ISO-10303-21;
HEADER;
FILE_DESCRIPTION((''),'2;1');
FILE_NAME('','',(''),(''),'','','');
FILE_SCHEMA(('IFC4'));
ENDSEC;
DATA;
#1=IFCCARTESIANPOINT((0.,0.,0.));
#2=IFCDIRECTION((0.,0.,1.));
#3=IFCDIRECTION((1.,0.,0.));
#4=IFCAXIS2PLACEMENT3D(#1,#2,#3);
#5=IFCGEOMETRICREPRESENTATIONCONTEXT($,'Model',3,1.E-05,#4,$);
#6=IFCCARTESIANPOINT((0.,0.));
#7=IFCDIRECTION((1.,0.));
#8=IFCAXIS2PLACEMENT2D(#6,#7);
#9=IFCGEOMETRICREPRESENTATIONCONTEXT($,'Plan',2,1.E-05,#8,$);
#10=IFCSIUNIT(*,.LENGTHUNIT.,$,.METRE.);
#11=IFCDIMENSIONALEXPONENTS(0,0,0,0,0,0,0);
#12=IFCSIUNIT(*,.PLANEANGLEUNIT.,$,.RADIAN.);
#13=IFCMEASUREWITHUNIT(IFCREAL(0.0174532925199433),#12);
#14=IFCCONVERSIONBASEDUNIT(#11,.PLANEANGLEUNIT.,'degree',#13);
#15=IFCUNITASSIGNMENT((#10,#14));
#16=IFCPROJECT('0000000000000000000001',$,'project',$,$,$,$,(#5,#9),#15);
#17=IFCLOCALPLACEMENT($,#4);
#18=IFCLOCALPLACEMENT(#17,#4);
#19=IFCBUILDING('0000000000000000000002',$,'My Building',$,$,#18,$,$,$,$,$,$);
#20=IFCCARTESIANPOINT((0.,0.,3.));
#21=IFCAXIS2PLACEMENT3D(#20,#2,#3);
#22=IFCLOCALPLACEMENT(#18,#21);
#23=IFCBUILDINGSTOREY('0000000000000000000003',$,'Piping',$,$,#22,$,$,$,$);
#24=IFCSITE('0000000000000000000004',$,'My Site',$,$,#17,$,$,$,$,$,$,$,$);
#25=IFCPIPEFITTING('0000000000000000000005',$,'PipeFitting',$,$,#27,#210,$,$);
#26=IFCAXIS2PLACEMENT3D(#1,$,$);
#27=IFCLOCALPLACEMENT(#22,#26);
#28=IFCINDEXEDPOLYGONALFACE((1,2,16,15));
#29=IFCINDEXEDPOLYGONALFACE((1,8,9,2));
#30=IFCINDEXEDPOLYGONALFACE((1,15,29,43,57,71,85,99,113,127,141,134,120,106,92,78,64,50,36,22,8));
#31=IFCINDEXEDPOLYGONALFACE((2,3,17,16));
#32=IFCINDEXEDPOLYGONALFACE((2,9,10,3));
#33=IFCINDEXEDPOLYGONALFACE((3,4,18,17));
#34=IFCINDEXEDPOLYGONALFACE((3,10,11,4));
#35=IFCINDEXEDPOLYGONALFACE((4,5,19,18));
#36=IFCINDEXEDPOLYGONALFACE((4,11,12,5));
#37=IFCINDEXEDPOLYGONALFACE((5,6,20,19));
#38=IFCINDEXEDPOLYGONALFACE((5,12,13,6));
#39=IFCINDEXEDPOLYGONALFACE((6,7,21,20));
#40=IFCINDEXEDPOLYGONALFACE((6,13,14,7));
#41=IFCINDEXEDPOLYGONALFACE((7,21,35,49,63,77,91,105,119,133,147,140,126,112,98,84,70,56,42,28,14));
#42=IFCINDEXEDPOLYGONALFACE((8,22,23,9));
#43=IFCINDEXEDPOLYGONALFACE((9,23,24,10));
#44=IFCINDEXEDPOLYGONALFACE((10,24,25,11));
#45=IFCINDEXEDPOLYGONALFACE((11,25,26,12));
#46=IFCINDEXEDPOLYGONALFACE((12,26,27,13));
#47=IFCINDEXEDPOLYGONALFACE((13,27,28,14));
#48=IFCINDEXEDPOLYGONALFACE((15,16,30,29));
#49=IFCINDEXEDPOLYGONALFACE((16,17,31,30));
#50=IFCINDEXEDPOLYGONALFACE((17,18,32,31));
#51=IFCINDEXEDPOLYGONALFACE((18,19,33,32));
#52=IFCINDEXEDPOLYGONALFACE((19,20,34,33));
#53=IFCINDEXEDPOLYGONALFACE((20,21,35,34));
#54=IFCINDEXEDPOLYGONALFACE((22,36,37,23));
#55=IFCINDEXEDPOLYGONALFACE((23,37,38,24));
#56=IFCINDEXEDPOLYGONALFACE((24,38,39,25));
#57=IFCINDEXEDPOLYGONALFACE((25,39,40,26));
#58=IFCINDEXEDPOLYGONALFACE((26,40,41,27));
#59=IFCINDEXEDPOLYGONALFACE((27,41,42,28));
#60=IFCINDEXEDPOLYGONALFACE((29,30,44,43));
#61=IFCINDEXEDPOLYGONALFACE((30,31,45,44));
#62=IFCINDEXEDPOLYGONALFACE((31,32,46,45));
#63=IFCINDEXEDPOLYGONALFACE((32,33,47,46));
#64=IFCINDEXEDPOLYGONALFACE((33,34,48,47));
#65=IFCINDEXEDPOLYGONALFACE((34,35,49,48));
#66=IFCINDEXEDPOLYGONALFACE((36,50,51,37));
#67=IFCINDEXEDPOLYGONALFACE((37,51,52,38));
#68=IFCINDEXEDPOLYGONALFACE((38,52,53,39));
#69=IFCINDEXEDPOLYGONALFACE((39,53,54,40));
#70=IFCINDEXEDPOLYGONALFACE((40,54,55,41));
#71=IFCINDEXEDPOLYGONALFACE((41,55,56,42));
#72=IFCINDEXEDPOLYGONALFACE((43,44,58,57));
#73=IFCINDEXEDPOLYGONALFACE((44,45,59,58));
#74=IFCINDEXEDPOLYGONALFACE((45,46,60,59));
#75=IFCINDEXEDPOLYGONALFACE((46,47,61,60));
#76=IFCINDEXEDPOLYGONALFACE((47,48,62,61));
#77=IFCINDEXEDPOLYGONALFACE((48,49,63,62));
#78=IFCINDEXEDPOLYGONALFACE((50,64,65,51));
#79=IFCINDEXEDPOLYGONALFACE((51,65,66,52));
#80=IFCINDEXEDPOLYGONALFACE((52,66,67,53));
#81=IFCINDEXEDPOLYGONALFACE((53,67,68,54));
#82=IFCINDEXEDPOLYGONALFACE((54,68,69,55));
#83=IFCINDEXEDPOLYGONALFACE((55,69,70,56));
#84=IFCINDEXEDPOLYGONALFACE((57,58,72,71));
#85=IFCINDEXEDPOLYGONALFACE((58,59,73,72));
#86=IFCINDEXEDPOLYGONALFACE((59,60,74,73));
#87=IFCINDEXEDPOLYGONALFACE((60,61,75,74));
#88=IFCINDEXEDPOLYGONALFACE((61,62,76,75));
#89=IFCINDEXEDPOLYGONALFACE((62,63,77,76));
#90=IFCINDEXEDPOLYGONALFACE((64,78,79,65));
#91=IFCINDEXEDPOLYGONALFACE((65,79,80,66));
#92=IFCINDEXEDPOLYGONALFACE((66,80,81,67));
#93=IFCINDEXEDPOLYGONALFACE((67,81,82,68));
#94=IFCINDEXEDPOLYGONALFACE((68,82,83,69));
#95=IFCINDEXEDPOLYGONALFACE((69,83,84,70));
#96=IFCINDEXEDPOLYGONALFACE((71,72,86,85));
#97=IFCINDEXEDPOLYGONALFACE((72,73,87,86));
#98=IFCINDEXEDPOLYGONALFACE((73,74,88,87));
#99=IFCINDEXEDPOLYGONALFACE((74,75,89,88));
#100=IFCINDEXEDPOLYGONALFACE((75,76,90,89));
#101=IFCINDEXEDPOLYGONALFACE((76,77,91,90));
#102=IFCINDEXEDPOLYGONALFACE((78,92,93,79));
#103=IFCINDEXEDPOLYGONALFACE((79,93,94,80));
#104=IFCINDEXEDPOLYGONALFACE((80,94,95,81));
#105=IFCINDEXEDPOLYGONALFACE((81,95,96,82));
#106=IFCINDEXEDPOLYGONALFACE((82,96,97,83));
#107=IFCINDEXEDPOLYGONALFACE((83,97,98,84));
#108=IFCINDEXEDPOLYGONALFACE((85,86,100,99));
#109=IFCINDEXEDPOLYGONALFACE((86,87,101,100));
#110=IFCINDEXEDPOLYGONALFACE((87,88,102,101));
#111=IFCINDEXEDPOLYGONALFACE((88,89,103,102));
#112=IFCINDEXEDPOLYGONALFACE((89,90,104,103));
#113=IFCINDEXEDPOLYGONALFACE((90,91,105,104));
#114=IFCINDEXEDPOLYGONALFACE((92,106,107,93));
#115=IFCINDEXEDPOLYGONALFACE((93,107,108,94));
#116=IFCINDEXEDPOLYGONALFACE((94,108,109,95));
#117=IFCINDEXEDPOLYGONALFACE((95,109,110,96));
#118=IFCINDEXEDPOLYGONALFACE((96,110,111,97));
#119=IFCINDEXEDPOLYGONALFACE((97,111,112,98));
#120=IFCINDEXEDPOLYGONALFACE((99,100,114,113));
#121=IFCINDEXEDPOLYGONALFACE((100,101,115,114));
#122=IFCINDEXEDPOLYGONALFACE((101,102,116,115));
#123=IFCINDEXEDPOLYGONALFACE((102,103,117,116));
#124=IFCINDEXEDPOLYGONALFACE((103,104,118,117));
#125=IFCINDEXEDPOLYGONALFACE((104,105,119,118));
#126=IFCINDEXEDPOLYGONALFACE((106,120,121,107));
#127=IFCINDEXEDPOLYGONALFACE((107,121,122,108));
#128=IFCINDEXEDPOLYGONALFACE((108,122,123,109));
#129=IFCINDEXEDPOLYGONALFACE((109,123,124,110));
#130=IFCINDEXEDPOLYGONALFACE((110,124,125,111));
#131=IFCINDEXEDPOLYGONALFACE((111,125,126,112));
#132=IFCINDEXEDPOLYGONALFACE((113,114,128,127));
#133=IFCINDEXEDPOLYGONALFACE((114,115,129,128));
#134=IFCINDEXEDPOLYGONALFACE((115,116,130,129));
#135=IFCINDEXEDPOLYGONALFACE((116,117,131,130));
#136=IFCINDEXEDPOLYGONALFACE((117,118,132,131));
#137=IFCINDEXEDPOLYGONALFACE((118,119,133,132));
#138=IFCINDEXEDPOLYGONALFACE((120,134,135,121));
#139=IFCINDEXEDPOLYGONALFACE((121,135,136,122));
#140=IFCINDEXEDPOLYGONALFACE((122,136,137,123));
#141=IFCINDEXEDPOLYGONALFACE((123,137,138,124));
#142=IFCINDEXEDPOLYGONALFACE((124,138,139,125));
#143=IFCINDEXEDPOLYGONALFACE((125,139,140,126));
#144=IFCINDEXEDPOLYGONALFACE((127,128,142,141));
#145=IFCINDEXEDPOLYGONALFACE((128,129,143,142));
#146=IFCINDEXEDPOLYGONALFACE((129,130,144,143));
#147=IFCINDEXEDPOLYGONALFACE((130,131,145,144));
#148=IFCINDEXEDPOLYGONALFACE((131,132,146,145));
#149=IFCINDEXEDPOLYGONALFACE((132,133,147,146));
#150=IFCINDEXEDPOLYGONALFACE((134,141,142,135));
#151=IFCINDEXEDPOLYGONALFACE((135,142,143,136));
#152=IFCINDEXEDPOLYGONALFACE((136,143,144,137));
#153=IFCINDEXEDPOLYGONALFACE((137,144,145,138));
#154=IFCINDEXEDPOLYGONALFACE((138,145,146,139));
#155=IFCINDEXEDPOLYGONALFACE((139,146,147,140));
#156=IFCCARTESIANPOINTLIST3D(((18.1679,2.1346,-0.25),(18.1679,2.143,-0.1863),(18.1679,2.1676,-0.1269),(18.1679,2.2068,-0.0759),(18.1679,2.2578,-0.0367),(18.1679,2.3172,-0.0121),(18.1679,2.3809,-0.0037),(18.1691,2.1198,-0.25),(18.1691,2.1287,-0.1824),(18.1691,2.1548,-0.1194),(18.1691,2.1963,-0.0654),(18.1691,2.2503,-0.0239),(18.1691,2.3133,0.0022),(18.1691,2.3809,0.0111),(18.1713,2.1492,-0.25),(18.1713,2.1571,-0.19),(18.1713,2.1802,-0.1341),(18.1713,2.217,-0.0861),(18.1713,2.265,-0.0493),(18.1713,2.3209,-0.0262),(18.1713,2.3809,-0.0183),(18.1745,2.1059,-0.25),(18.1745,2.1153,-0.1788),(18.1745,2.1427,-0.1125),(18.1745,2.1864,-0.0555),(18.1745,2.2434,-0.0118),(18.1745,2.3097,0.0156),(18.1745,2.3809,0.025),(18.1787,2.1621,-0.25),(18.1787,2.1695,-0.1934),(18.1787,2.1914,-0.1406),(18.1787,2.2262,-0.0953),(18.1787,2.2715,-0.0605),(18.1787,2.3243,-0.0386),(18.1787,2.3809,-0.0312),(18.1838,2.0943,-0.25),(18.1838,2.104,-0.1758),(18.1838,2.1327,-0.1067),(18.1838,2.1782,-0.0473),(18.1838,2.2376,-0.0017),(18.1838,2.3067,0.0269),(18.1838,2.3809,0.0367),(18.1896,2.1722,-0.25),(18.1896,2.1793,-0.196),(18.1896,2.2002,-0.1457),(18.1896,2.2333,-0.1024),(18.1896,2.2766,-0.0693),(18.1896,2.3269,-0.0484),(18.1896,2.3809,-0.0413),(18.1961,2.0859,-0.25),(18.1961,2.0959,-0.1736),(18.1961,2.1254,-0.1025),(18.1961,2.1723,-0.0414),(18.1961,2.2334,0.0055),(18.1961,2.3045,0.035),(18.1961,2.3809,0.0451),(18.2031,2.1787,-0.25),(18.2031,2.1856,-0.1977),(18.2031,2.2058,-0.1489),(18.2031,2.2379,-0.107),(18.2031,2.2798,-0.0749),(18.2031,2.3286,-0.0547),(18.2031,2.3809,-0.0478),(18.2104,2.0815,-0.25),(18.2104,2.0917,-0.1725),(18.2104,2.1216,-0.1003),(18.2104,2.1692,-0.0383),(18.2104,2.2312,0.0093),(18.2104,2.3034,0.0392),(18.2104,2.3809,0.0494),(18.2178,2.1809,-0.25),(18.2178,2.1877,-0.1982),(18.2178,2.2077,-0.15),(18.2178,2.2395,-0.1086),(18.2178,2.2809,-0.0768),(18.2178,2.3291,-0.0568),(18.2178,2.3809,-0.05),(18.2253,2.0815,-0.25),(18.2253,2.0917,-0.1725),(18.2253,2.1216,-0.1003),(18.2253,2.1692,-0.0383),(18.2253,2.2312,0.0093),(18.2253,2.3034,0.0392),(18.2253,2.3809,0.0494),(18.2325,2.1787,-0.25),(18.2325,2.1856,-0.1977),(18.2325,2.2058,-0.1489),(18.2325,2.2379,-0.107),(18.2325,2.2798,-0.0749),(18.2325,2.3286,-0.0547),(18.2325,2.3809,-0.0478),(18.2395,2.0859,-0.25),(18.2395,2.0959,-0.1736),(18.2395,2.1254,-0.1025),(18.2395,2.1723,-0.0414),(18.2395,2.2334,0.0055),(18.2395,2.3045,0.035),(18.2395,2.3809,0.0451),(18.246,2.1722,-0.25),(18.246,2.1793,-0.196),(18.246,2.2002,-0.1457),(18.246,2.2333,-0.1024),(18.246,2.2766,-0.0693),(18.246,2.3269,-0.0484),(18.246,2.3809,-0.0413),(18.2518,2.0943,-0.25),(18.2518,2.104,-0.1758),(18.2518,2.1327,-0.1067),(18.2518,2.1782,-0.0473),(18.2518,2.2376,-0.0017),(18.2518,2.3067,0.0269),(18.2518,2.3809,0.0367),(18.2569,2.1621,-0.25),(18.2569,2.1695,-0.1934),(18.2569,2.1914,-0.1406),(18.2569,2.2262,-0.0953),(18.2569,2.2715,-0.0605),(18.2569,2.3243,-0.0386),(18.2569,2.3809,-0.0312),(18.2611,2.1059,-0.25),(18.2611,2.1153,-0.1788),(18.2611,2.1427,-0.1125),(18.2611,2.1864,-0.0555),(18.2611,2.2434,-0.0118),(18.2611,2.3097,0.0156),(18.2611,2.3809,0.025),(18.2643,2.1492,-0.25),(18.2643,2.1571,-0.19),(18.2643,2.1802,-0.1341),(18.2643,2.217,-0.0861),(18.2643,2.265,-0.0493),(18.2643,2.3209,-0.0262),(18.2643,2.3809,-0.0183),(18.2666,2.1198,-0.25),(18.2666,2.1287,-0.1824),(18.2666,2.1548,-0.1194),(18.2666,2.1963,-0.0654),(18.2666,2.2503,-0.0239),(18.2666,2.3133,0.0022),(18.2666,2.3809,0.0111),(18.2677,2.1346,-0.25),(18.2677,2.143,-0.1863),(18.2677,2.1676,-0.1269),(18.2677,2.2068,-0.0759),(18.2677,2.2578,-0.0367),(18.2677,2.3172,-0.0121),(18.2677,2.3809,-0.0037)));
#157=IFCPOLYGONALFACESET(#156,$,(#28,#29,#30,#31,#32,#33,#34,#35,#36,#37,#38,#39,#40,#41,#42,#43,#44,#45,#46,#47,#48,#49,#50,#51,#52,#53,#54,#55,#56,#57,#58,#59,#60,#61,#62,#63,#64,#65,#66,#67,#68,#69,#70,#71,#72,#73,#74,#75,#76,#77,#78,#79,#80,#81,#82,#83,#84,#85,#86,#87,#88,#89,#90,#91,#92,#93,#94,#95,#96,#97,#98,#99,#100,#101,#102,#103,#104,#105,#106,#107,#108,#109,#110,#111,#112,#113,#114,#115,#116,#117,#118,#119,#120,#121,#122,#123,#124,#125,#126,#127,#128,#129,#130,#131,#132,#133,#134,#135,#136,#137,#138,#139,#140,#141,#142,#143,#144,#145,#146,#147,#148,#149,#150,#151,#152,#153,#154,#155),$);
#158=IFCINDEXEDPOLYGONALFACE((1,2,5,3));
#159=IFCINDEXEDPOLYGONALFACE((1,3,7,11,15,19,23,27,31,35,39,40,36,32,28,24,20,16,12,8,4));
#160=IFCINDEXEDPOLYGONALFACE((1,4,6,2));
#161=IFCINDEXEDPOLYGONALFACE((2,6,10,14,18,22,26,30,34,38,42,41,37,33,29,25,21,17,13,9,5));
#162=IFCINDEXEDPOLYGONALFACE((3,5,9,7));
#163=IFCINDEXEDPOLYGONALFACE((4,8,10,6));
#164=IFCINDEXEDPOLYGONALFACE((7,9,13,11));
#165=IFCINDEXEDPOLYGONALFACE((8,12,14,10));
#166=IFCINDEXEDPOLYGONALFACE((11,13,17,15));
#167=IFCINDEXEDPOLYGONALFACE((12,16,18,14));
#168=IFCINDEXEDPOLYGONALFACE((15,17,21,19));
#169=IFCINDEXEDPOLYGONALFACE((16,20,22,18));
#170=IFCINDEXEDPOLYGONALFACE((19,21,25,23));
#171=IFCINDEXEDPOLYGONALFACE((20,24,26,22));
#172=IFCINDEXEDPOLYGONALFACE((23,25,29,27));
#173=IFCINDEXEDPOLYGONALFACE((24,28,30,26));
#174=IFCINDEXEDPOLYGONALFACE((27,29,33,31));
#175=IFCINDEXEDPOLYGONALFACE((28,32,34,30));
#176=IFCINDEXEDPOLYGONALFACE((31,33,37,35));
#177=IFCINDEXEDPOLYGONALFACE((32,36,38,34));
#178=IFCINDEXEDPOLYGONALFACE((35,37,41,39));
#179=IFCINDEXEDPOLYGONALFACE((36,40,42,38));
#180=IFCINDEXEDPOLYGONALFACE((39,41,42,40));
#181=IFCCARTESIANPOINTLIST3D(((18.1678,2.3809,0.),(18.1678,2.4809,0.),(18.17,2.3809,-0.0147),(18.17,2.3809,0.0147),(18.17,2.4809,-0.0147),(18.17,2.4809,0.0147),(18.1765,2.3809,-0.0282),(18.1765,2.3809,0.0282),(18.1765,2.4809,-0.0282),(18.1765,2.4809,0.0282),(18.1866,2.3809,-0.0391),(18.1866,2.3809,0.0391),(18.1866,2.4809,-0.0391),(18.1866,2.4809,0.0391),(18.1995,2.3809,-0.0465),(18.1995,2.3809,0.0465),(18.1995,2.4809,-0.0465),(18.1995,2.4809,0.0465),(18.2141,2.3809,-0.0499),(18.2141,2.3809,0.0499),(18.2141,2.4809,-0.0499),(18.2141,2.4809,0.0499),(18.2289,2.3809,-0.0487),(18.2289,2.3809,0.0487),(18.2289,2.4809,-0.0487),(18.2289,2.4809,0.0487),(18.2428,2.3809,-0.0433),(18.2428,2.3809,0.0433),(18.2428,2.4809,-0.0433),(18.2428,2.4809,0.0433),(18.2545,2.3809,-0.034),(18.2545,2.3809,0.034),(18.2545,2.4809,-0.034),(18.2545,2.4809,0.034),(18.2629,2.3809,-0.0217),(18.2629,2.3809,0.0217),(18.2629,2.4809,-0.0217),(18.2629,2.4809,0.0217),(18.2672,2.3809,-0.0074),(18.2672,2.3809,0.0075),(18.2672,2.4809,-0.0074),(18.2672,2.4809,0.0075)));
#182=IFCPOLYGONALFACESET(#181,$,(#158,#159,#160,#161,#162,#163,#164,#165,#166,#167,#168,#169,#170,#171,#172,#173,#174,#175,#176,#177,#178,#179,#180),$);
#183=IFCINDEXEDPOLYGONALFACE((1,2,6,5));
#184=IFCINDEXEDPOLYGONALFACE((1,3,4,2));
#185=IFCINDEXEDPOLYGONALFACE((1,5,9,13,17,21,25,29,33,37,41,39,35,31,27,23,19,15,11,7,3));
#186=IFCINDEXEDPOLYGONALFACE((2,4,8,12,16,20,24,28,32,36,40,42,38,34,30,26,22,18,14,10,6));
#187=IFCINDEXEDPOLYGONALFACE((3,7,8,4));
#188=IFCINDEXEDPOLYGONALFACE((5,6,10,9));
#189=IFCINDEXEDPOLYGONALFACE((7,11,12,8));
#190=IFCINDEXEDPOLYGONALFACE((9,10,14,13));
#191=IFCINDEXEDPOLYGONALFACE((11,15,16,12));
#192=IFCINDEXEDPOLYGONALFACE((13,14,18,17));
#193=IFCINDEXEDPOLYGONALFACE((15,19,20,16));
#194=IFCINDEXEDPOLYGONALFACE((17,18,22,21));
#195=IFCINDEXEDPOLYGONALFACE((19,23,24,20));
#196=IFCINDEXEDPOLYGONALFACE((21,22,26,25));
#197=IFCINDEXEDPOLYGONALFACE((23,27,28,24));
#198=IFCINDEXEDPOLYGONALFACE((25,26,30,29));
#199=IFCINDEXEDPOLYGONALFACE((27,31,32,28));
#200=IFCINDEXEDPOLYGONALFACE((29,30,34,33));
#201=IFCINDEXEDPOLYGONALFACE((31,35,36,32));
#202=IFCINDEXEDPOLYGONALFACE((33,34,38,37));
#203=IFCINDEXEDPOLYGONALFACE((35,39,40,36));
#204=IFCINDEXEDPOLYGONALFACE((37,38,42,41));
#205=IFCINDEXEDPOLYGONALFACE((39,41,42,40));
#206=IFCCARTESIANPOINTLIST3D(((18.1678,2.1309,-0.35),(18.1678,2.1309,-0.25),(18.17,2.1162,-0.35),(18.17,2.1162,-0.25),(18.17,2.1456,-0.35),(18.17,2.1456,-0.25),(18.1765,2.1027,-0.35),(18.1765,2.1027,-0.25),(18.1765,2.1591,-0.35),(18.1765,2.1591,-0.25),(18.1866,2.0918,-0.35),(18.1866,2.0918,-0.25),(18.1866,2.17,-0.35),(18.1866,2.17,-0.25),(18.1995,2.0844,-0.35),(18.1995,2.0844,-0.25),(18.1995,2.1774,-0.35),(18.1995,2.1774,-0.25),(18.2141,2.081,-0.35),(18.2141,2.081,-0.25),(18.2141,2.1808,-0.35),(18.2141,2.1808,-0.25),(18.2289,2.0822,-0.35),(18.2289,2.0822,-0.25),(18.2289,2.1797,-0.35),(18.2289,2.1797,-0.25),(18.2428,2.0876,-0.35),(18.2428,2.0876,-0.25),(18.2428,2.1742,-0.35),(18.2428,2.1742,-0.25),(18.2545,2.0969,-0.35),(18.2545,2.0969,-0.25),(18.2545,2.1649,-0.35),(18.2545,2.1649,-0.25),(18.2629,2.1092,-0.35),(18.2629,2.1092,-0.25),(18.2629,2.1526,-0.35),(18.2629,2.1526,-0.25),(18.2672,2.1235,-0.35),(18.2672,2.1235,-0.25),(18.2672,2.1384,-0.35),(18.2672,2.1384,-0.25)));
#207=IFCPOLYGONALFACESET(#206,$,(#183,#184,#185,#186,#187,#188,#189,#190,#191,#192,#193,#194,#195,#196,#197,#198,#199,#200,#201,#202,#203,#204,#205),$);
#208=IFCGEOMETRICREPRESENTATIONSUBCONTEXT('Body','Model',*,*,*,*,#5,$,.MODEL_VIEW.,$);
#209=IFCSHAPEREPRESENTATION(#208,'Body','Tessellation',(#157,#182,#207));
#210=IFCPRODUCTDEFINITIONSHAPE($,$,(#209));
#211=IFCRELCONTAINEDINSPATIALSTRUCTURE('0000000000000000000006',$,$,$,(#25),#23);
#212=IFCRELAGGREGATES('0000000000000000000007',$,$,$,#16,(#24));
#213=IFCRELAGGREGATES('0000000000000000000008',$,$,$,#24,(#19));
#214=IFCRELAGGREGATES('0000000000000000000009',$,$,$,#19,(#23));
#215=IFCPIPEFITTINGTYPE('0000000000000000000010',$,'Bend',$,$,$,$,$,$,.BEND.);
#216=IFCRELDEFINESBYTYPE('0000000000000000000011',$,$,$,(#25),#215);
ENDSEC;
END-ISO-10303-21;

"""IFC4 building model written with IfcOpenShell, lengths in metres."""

from ifc_helpers import new_model, entity, si_unit, converted_unit, frame, origin_with_axes, origin_2d_with_axis, place, context, subcontext, project, spatial, circle, extrude, source, transform, mapped, type_object, type_shapes, element, save


model = new_model("IFC4")

# Units and contexts
model_context = context("Model", 3, precision=1e-05, world=origin_with_axes())
plan_context = context("Plan", 2, precision=1e-05, world=origin_2d_with_axis())
body_context = subcontext(model_context, "Body", "Model", "MODEL_VIEW")
ifc_project = project(units=[si_unit("LENGTHUNIT", "METRE"), converted_unit("PLANEANGLEUNIT", "degree", entity("IfcReal", 0.0174532925199433), si_unit("PLANEANGLEUNIT", "RADIAN"), dimensions=[0, 0, 0, 0, 0, 0, 0])], contexts=[model_context, plan_context])

# Site, building, storey
site_placement = place(None, origin_with_axes())
site = spatial("IfcSite", under=ifc_project, at=site_placement, Name="My Site")
building_placement = place(site_placement, origin_with_axes())
building = spatial("IfcBuilding", under=site, at=building_placement, Name="My Building")
storey_placement = place(building_placement, frame((0.0, 0.0, 3.0), z_axis=(0.0, 0.0, 1.0), x_axis=(1.0, 0.0, 0.0)))
storey = spatial("IfcBuildingStorey", under=building, at=storey_placement, Name="Piping")

# Pipe fitting
pipe_fitting_type = type_object("IfcPipeFittingType", Name="Bend", PredefinedType="BEND")
shared_shape = source(origin_with_axes(), body_context, "Body", "SolidModel", [
    entity("IfcSweptDiskSolid", entity("IfcIndexedPolyCurve", entity("IfcCartesianPointList3D", [[0.0, 0.0, -0.1], [0.0, -0.0732, -0.2768], [0.0, -0.25, -0.35]]), [entity("IfcArcIndex", [1, 2, 3])]), 0.05),
    extrude(circle(Radius=0.05), origin_with_axes(), (0.0, 0.0, -1.0), 0.1),
    extrude(circle(Radius=0.05), frame((0.0, -0.25, -0.35), z_axis=(0.0, -1.0, 0.0), x_axis=(1.0, 0.0, 0.0)), (0.0, 0.0, 1.0), 0.1),
])
type_shapes(pipe_fitting_type, [shared_shape])
for number, where, z_axis, x_axis, name in (
    (1, (18.2178, 2.4809, 0.0), (0.0, 1.0, 0.0), (-1.0, 0.0, 0.0), "PipeFitting"),
):
    element("IfcPipeFitting", number, at=place(storey_placement, frame(where, z_axis=z_axis, x_axis=x_axis)), inside=storey, type_object=pipe_fitting_type, Name=name, context=body_context, shape_type="MappedRepresentation", body=[
        mapped(shared_shape, transform((0.0, 0.0, 0.0), x_axis=(1.0, 0.0, 0.0), y_axis=(0.0, 1.0, 0.0), z_axis=(0.0, 0.0, 1.0), scale=1.0)),
    ])

save(model, "model.ifc")
